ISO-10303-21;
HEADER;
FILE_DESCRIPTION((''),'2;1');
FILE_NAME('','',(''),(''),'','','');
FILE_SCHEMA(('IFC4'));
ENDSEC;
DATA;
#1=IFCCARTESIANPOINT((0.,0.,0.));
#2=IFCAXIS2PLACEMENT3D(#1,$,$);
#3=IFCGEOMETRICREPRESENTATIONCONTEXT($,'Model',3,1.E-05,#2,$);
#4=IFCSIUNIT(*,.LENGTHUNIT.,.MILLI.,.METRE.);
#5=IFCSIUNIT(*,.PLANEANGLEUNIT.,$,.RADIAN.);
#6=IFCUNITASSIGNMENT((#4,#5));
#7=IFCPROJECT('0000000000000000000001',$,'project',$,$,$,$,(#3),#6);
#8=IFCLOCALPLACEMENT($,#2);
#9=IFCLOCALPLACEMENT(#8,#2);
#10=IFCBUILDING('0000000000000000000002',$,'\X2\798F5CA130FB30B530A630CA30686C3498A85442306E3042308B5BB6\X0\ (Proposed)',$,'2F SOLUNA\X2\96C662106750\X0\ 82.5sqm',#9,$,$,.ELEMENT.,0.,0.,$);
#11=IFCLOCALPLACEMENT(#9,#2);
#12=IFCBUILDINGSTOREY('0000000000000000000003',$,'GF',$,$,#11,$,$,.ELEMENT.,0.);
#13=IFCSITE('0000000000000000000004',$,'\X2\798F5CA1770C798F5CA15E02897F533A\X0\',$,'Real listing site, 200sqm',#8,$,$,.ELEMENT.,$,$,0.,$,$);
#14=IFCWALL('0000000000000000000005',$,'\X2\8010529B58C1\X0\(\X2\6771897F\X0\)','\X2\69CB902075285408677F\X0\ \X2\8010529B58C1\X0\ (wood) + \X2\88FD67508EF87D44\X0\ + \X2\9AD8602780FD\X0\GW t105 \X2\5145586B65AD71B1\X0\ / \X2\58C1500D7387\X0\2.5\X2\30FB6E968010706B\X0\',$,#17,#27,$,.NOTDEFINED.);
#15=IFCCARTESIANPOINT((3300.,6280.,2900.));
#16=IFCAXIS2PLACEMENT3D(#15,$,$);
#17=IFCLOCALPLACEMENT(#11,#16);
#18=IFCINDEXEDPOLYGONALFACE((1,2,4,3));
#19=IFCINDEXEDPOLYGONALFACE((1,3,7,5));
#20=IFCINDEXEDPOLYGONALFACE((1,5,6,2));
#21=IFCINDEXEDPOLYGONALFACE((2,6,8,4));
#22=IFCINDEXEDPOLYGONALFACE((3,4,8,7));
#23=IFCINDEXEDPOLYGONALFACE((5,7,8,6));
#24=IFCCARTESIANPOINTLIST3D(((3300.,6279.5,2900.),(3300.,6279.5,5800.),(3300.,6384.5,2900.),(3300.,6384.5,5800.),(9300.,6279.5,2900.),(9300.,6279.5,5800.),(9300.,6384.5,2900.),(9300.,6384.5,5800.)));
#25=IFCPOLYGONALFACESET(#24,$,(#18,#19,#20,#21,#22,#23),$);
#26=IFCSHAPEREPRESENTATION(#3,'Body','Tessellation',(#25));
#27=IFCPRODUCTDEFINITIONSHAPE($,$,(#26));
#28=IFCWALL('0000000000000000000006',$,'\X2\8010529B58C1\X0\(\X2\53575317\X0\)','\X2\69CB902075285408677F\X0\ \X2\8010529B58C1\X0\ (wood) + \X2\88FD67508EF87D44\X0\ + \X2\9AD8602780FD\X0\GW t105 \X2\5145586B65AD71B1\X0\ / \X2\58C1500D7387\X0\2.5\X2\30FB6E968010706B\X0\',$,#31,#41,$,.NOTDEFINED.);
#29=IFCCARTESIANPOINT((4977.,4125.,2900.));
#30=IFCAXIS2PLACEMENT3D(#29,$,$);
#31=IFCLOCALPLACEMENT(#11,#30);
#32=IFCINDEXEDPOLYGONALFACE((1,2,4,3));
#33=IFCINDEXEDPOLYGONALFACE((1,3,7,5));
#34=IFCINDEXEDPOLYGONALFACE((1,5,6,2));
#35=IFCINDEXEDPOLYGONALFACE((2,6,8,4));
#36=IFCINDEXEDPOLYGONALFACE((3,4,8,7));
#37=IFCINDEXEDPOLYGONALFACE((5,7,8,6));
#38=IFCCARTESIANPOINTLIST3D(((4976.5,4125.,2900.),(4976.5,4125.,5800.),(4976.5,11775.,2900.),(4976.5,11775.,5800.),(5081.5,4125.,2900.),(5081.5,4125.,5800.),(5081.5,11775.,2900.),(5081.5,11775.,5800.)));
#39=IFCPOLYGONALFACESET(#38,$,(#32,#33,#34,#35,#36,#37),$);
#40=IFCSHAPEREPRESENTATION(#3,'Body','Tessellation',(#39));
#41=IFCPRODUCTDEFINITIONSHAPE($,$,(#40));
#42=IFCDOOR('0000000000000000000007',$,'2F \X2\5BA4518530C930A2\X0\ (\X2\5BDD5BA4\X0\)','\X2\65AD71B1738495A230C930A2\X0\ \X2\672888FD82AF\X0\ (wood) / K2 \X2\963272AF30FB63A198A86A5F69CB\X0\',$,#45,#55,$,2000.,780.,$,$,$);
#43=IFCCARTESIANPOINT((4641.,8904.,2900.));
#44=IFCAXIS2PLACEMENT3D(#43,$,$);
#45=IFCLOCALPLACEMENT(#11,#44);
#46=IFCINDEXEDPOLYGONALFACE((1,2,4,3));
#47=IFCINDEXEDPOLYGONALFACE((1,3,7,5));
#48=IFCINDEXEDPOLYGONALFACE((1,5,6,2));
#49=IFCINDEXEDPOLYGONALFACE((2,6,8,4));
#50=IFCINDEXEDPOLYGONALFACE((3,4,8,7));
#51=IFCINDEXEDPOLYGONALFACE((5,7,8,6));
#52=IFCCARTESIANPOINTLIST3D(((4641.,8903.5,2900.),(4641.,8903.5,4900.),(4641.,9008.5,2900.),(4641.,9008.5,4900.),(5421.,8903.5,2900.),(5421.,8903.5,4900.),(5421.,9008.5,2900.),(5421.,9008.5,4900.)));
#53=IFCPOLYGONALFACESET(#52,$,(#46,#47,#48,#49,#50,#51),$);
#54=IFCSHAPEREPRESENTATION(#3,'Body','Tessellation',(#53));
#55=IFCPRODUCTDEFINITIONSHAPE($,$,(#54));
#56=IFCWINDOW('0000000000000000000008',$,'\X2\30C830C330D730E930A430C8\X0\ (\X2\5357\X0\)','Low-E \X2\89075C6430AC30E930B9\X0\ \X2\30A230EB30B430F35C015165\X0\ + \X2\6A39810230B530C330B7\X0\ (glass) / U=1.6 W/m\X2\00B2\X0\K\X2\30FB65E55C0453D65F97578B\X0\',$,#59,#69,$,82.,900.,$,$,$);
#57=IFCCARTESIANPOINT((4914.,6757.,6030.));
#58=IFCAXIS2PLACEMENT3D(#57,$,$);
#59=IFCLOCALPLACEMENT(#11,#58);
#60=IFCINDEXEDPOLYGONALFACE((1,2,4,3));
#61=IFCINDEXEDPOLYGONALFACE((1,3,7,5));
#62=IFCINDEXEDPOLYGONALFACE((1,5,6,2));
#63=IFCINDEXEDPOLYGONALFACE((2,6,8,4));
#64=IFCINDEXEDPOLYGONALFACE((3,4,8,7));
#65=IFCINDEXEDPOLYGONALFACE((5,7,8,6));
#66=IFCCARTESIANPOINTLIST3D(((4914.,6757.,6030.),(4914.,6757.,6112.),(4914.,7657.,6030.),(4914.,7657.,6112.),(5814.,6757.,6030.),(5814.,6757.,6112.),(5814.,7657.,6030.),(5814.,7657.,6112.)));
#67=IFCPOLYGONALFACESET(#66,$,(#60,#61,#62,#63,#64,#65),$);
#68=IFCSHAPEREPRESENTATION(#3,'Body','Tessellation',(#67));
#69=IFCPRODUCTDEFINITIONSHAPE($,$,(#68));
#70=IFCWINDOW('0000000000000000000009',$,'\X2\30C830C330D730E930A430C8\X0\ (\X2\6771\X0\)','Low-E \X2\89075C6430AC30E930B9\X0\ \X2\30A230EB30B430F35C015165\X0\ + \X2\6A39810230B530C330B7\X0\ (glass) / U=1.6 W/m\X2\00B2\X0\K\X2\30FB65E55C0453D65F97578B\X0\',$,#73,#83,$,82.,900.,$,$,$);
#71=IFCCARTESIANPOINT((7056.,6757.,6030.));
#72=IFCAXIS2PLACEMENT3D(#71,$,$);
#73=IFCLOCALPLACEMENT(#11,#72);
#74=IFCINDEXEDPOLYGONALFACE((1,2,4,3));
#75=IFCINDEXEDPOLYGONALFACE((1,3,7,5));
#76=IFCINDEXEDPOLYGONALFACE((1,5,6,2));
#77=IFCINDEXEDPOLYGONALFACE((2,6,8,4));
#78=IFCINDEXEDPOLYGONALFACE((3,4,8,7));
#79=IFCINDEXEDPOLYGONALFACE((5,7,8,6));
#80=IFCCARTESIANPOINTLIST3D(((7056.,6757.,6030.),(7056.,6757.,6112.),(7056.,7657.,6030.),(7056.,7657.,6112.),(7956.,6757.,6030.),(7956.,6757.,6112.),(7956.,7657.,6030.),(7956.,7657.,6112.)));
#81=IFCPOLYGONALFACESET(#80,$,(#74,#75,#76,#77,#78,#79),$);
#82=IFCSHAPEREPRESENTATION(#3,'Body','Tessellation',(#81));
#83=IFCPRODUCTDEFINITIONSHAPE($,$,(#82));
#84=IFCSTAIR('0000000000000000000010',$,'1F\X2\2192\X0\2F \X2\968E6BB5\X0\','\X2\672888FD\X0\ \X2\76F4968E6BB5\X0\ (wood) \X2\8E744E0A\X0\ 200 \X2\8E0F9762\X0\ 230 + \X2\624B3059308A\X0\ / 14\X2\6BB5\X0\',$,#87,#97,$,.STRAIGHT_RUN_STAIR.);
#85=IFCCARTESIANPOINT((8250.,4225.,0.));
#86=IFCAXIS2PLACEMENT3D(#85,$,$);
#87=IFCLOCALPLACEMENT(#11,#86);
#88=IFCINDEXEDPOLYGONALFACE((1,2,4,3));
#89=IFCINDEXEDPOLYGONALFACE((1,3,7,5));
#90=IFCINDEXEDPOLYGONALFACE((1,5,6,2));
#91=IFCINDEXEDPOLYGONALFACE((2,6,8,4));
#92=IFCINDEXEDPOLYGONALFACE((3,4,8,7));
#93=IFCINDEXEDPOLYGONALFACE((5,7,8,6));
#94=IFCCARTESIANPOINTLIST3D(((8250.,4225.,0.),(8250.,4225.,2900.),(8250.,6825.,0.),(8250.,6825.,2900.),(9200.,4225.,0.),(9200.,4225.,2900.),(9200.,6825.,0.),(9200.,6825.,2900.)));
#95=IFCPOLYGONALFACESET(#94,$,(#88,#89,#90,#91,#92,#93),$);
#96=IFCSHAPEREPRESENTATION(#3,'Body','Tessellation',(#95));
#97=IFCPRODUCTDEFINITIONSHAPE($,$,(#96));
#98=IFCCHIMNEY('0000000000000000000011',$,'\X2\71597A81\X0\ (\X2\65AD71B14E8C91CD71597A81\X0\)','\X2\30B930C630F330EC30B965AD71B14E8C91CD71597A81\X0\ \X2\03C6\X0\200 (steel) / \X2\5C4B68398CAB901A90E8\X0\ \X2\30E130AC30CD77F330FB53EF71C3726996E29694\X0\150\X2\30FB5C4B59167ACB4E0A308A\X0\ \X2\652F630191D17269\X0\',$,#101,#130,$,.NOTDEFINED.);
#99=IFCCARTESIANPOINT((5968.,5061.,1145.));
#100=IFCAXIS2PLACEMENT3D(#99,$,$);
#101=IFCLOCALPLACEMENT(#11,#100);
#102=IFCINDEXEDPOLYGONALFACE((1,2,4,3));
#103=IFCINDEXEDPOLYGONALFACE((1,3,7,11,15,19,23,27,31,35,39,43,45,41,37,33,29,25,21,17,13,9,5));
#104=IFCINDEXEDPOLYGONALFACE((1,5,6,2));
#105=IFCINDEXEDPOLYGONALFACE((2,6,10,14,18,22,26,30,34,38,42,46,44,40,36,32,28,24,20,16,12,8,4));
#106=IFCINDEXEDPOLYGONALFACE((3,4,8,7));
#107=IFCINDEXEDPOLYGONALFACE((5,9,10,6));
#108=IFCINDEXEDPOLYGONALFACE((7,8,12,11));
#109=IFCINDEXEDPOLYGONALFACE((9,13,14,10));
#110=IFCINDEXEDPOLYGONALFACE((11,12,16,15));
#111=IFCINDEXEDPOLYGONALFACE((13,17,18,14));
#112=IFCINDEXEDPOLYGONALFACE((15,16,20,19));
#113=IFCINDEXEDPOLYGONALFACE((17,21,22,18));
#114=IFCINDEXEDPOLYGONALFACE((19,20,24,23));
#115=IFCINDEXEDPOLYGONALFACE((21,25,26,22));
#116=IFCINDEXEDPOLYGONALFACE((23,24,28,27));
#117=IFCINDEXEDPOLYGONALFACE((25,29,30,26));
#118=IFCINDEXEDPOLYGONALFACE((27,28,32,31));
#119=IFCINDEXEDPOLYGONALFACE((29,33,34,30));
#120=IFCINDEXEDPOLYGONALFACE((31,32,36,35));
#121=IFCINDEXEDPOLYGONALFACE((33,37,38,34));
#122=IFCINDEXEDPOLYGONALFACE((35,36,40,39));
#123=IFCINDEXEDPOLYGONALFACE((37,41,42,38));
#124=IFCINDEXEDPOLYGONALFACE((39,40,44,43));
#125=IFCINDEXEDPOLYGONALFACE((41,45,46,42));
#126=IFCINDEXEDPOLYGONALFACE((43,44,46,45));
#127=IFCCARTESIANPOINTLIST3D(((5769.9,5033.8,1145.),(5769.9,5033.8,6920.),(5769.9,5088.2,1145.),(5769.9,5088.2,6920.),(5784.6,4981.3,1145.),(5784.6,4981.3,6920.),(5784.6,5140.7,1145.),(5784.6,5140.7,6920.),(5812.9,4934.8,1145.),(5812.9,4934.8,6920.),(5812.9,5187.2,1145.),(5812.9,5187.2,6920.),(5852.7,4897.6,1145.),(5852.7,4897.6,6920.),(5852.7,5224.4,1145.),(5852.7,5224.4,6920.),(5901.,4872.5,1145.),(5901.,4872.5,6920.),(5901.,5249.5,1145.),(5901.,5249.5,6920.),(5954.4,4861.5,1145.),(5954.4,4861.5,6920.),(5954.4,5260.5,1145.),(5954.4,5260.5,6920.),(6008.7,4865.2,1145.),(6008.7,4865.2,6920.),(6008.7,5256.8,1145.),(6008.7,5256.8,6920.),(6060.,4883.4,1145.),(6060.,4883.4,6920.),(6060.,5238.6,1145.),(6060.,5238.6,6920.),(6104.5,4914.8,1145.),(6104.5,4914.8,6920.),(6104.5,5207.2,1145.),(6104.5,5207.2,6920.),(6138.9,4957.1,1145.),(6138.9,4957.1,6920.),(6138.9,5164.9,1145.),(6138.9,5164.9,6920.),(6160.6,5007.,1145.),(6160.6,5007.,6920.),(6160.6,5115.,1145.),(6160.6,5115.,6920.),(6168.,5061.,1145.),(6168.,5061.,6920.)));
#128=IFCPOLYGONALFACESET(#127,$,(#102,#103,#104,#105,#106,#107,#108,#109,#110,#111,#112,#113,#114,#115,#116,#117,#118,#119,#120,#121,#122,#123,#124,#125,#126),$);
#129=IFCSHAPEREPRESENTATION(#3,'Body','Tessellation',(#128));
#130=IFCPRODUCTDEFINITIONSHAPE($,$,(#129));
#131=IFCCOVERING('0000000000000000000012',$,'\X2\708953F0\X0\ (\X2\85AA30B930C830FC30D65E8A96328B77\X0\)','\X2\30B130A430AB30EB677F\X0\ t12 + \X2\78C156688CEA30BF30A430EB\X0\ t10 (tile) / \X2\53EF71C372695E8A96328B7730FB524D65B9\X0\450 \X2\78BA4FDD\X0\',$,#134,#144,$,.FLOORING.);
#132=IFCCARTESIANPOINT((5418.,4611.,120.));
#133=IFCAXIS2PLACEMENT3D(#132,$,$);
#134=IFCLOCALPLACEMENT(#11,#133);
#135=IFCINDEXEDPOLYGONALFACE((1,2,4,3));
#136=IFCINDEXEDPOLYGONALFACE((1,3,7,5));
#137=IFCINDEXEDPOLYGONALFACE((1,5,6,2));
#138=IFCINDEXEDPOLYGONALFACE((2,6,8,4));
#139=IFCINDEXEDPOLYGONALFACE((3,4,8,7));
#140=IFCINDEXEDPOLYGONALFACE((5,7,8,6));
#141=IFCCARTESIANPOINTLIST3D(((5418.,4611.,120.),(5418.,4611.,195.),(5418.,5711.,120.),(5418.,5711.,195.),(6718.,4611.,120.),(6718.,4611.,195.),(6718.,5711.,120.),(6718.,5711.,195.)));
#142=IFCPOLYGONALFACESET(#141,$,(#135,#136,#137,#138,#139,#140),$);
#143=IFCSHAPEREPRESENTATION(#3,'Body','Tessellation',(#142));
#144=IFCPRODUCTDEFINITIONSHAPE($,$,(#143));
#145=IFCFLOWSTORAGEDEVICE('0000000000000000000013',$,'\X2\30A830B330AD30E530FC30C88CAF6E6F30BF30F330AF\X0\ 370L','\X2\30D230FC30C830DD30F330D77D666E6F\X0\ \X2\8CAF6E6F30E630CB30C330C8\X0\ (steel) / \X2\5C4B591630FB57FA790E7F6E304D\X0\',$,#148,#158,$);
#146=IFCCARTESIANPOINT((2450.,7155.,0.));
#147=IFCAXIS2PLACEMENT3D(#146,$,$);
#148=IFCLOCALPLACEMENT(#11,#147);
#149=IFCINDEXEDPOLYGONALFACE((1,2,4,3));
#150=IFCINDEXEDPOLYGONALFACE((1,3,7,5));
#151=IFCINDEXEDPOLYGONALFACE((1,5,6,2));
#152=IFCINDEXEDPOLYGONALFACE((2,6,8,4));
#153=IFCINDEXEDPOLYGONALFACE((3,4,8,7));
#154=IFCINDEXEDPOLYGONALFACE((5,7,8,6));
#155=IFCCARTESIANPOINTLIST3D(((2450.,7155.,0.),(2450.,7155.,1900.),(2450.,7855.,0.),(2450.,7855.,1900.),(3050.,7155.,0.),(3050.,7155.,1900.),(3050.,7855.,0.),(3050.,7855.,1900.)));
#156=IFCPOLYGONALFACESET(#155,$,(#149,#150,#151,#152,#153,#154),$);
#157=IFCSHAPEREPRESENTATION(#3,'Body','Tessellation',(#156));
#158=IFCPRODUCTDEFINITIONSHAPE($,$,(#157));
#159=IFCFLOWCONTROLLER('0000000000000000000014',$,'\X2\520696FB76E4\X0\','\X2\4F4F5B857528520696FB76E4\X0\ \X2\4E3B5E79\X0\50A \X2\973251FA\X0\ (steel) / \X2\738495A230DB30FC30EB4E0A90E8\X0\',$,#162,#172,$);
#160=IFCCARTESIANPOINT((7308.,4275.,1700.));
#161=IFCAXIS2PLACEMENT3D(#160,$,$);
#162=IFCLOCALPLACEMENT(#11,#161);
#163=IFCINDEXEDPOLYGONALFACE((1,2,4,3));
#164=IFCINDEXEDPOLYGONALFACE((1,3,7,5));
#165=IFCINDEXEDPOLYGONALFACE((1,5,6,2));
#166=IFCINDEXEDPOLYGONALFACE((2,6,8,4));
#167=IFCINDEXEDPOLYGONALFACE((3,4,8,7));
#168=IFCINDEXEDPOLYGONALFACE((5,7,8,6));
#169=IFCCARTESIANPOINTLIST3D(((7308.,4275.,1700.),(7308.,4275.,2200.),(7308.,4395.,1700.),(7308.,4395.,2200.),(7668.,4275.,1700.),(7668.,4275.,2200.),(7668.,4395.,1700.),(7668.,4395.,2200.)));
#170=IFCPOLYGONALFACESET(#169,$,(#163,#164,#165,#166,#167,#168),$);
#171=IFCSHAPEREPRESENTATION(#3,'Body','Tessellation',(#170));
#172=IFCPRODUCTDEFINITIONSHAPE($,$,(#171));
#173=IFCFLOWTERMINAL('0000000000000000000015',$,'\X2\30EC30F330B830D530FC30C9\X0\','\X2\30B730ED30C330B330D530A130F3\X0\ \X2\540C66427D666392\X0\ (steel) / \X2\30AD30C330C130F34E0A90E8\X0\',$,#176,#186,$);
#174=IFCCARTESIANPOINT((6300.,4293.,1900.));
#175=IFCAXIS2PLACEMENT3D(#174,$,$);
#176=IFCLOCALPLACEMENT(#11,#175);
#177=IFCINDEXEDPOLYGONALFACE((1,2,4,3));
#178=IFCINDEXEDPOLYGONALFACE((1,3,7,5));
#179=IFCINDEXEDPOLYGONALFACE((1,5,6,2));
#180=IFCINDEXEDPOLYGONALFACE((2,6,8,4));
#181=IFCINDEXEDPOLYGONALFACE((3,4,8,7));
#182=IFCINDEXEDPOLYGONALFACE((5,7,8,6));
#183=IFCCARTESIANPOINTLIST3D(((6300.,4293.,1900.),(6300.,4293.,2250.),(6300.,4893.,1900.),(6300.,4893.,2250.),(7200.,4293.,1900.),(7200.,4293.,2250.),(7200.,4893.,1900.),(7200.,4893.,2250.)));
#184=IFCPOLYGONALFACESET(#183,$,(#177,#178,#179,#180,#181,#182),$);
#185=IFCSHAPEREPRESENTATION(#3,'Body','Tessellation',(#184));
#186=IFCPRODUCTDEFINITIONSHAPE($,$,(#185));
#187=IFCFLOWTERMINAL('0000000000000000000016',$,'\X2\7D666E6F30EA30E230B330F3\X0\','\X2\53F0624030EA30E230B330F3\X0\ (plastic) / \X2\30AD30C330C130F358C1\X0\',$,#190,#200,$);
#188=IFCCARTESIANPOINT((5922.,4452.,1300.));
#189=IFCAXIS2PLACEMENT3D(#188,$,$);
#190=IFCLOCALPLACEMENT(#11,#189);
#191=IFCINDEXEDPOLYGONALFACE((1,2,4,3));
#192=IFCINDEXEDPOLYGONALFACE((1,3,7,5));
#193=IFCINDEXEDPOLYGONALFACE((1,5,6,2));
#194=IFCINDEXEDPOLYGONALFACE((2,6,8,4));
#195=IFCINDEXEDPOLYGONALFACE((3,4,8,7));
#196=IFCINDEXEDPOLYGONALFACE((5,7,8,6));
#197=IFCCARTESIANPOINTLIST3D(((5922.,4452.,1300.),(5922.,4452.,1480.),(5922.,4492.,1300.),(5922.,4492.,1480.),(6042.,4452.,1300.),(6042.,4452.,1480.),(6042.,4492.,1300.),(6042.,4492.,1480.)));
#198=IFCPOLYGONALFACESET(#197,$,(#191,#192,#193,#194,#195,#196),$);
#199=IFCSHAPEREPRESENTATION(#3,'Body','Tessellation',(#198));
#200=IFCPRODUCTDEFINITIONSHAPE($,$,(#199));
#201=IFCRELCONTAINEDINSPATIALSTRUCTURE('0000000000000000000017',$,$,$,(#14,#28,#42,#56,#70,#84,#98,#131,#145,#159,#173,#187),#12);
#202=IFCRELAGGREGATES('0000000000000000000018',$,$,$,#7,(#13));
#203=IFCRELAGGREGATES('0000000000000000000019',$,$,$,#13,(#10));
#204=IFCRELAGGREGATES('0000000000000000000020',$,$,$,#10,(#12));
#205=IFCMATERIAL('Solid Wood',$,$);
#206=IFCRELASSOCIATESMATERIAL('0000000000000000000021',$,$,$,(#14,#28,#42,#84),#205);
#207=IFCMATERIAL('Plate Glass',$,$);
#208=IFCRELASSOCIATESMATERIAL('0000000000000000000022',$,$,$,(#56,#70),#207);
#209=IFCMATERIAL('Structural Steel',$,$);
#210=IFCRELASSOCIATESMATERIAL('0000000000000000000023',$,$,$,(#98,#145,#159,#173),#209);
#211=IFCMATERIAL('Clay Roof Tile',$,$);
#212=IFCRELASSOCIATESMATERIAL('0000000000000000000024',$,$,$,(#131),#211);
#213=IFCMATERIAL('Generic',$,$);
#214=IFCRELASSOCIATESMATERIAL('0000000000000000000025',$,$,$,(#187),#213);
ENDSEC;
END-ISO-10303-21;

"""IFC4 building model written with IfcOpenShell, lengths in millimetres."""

from ifc_helpers import new_model, si_unit, frame, frame_2d, origin, origin_2d, place, context, project, spatial, rectangle, circle, extrude, material, element, fill, save


model = new_model("IFC4")

# Units and contexts
model_context = context("Model", 3, precision=1e-05, world=origin())
ifc_project = project(units=[si_unit("LENGTHUNIT", "METRE", prefix="MILLI"), si_unit("PLANEANGLEUNIT", "RADIAN")], contexts=[model_context])

# Site, building, storey
site_placement = place(None, origin())
site = spatial("IfcSite", under=ifc_project, at=site_placement, Name="福岡県福岡市西区", ObjectType="Real listing site, 200sqm", CompositionType="ELEMENT", RefElevation=0.0)
building_placement = place(site_placement, origin())
building = spatial("IfcBuilding", under=site, at=building_placement, Name="福岡・サウナと水風呂のある家 (Proposed)", ObjectType="2F SOLUNA集成材 82.5sqm", CompositionType="ELEMENT", ElevationOfRefHeight=0.0, ElevationOfTerrain=0.0)
storey_placement = place(building_placement, origin())
storey = spatial("IfcBuildingStorey", under=building, at=storey_placement, Name="GF", CompositionType="ELEMENT", Elevation=0.0)

# Shared definitions
ifc_material_1 = material(Name="Solid Wood")

# Wall
wall_1_placement = place(storey_placement, frame((3300.0, 6280.0, 2900.0)))
element("IfcWall", 1, at=wall_1_placement, inside=storey, material=ifc_material_1, Name="耐力壁(東西)", Description="構造用合板 耐力壁 (wood) + 製材軸組 + 高性能GW t105 充填断熱 / 壁倍率2.5・準耐火", PredefinedType="NOTDEFINED", context=model_context, shape_type="SweptSolid", body=[
    extrude(rectangle(XDim=6000.0, YDim=105.0, at=frame_2d((3000.0, 52.0))), frame((3300.0, 6280.0, 2900.0)), (0.0, 0.0, 1.0), 2900.0),
])

# Wall, opening, door
wall_2_placement = place(storey_placement, frame((4977.0, 4125.0, 2900.0)))
wall_2 = element("IfcWall", 2, at=wall_2_placement, inside=storey, material=ifc_material_1, Name="耐力壁(南北)", Description="構造用合板 耐力壁 (wood) + 製材軸組 + 高性能GW t105 充填断熱 / 壁倍率2.5・準耐火", PredefinedType="NOTDEFINED", context=model_context, shape_type="SweptSolid", body=[
    extrude(rectangle(XDim=105.0, YDim=7650.0, at=frame_2d((52.0, 3825.0))), frame((4977.0, 4125.0, 2900.0)), (0.0, 0.0, 1.0), 2900.0),
])
opening_placement = place(storey_placement, frame((4641.0, 8904.0, 2900.0)))
opening = element("IfcOpeningElement", 3, at=opening_placement, cuts=wall_2, PredefinedType="NOTDEFINED", context=model_context, shape_type="SweptSolid", body=[
    extrude(rectangle(XDim=780.0, YDim=105.0, at=frame_2d((390.0, 52.0))), frame((4641.0, 8904.0, 2900.0)), (0.0, 0.0, 1.0), 2000.0),
])
door_placement = place(storey_placement, frame((4641.0, 8904.0, 2900.0)))
door = element("IfcDoor", 4, at=door_placement, inside=storey, material=ifc_material_1, Name="2F 室内ドア (寝室)", Description="断熱玄関ドア 木製芯 (wood) / K2 防犯・採風機構", OverallHeight=2000.0, OverallWidth=780.0, context=model_context, shape_type="SweptSolid", body=[
    extrude(rectangle(XDim=780.0, YDim=105.0, at=frame_2d((390.0, 52.0))), frame((4641.0, 8904.0, 2900.0)), (0.0, 0.0, 1.0), 2000.0),
])
fill(opening, door)

# Windows
ifc_material_2 = material(Name="Plate Glass")
window_1_placement = place(storey_placement, frame((4914.0, 6757.0, 6030.0)))
element("IfcWindow", 5, at=window_1_placement, inside=storey, material=ifc_material_2, Name="トップライト (南)", Description="Low-E 複層ガラス アルゴン封入 + 樹脂サッシ (glass) / U=1.6 W/m²K・日射取得型", OverallHeight=82.0, OverallWidth=900.0, context=model_context, shape_type="SweptSolid", body=[
    extrude(rectangle(XDim=900.0, YDim=900.0, at=frame_2d((450.0, 450.0))), frame((4914.0, 6757.0, 6030.0)), (0.0, 0.0, 1.0), 82.0),
])
window_2_placement = place(storey_placement, frame((7056.0, 6757.0, 6030.0)))
element("IfcWindow", 6, at=window_2_placement, inside=storey, material=ifc_material_2, Name="トップライト (東)", Description="Low-E 複層ガラス アルゴン封入 + 樹脂サッシ (glass) / U=1.6 W/m²K・日射取得型", OverallHeight=82.0, OverallWidth=900.0, context=model_context, shape_type="SweptSolid", body=[
    extrude(rectangle(XDim=900.0, YDim=900.0, at=frame_2d((450.0, 450.0))), frame((7056.0, 6757.0, 6030.0)), (0.0, 0.0, 1.0), 82.0),
])

# Stair
stair_placement = place(storey_placement, frame((8250.0, 4225.0, 0.0)))
element("IfcStair", 7, at=stair_placement, inside=storey, material=ifc_material_1, Name="1F→2F 階段", Description="木製 直階段 (wood) 蹴上 200 踏面 230 + 手すり / 14段", PredefinedType="STRAIGHT_RUN_STAIR", context=model_context, shape_type="SweptSolid", body=[
    extrude(rectangle(XDim=950.0, YDim=2600.0, at=frame_2d((475.0, 1300.0))), frame((8250.0, 4225.0, 0.0)), (0.0, 0.0, 1.0), 2900.0),
])

# Chimney
ifc_material_3 = material(Name="Structural Steel")
chimney_placement = place(storey_placement, frame((5968.0, 5061.0, 1145.0)))
element("IfcChimney", 8, at=chimney_placement, inside=storey, material=ifc_material_3, Name="煙突 (断熱二重煙突)", Description="ステンレス断熱二重煙突 φ200 (steel) / 屋根貫通部 メガネ石・可燃物離隔150・屋外立上り 支持金物", PredefinedType="NOTDEFINED", context=model_context, shape_type="SweptSolid", body=[
    extrude(circle(Radius=200.0, at=origin_2d()), frame((5968.0, 5061.0, 1145.0)), (0.0, 0.0, 1.0), 5775.0),
])

# Covering
ifc_material_4 = material(Name="Clay Roof Tile")
covering_placement = place(storey_placement, frame((5418.0, 4611.0, 120.0)))
element("IfcCovering", 9, at=covering_placement, inside=storey, material=ifc_material_4, Name="炉台 (薪ストーブ床防護)", Description="ケイカル板 t12 + 磁器質タイル t10 (tile) / 可燃物床防護・前方450 確保", PredefinedType="FLOORING", context=model_context, shape_type="SweptSolid", body=[
    extrude(rectangle(XDim=1300.0, YDim=1100.0, at=frame_2d((650.0, 550.0))), frame((5418.0, 4611.0, 120.0)), (0.0, 0.0, 1.0), 75.0),
])

# Flow storage device
flow_storage_device_placement = place(storey_placement, frame((2450.0, 7155.0, 0.0)))
element("IfcFlowStorageDevice", 10, at=flow_storage_device_placement, inside=storey, material=ifc_material_3, Name="エコキュート貯湯タンク 370L", Description="ヒートポンプ給湯 貯湯ユニット (steel) / 屋外・基礎置き", context=model_context, shape_type="SweptSolid", body=[
    extrude(rectangle(XDim=600.0, YDim=700.0, at=frame_2d((300.0, 350.0))), frame((2450.0, 7155.0, 0.0)), (0.0, 0.0, 1.0), 1900.0),
])

# Flow controller
flow_controller_placement = place(storey_placement, frame((7308.0, 4275.0, 1700.0)))
element("IfcFlowController", 11, at=flow_controller_placement, inside=storey, material=ifc_material_3, Name="分電盤", Description="住宅用分電盤 主幹50A 露出 (steel) / 玄関ホール上部", context=model_context, shape_type="SweptSolid", body=[
    extrude(rectangle(XDim=360.0, YDim=120.0, at=frame_2d((180.0, 60.0))), frame((7308.0, 4275.0, 1700.0)), (0.0, 0.0, 1.0), 500.0),
])

# Flow terminals
flow_terminal_1_placement = place(storey_placement, frame((6300.0, 4293.0, 1900.0)))
element("IfcFlowTerminal", 12, at=flow_terminal_1_placement, inside=storey, material=ifc_material_3, Name="レンジフード", Description="シロッコファン 同時給排 (steel) / キッチン上部", context=model_context, shape_type="SweptSolid", body=[
    extrude(rectangle(XDim=900.0, YDim=600.0, at=frame_2d((450.0, 300.0))), frame((6300.0, 4293.0, 1900.0)), (0.0, 0.0, 1.0), 350.0),
])
ifc_material_5 = material(Name="Generic")
flow_terminal_2_placement = place(storey_placement, frame((5922.0, 4452.0, 1300.0)))
element("IfcFlowTerminal", 13, at=flow_terminal_2_placement, inside=storey, material=ifc_material_5, Name="給湯リモコン", Description="台所リモコン (plastic) / キッチン壁", context=model_context, shape_type="SweptSolid", body=[
    extrude(rectangle(XDim=120.0, YDim=40.0, at=frame_2d((60.0, 20.0))), frame((5922.0, 4452.0, 1300.0)), (0.0, 0.0, 1.0), 180.0),
])

save(model, "model.ifc")
